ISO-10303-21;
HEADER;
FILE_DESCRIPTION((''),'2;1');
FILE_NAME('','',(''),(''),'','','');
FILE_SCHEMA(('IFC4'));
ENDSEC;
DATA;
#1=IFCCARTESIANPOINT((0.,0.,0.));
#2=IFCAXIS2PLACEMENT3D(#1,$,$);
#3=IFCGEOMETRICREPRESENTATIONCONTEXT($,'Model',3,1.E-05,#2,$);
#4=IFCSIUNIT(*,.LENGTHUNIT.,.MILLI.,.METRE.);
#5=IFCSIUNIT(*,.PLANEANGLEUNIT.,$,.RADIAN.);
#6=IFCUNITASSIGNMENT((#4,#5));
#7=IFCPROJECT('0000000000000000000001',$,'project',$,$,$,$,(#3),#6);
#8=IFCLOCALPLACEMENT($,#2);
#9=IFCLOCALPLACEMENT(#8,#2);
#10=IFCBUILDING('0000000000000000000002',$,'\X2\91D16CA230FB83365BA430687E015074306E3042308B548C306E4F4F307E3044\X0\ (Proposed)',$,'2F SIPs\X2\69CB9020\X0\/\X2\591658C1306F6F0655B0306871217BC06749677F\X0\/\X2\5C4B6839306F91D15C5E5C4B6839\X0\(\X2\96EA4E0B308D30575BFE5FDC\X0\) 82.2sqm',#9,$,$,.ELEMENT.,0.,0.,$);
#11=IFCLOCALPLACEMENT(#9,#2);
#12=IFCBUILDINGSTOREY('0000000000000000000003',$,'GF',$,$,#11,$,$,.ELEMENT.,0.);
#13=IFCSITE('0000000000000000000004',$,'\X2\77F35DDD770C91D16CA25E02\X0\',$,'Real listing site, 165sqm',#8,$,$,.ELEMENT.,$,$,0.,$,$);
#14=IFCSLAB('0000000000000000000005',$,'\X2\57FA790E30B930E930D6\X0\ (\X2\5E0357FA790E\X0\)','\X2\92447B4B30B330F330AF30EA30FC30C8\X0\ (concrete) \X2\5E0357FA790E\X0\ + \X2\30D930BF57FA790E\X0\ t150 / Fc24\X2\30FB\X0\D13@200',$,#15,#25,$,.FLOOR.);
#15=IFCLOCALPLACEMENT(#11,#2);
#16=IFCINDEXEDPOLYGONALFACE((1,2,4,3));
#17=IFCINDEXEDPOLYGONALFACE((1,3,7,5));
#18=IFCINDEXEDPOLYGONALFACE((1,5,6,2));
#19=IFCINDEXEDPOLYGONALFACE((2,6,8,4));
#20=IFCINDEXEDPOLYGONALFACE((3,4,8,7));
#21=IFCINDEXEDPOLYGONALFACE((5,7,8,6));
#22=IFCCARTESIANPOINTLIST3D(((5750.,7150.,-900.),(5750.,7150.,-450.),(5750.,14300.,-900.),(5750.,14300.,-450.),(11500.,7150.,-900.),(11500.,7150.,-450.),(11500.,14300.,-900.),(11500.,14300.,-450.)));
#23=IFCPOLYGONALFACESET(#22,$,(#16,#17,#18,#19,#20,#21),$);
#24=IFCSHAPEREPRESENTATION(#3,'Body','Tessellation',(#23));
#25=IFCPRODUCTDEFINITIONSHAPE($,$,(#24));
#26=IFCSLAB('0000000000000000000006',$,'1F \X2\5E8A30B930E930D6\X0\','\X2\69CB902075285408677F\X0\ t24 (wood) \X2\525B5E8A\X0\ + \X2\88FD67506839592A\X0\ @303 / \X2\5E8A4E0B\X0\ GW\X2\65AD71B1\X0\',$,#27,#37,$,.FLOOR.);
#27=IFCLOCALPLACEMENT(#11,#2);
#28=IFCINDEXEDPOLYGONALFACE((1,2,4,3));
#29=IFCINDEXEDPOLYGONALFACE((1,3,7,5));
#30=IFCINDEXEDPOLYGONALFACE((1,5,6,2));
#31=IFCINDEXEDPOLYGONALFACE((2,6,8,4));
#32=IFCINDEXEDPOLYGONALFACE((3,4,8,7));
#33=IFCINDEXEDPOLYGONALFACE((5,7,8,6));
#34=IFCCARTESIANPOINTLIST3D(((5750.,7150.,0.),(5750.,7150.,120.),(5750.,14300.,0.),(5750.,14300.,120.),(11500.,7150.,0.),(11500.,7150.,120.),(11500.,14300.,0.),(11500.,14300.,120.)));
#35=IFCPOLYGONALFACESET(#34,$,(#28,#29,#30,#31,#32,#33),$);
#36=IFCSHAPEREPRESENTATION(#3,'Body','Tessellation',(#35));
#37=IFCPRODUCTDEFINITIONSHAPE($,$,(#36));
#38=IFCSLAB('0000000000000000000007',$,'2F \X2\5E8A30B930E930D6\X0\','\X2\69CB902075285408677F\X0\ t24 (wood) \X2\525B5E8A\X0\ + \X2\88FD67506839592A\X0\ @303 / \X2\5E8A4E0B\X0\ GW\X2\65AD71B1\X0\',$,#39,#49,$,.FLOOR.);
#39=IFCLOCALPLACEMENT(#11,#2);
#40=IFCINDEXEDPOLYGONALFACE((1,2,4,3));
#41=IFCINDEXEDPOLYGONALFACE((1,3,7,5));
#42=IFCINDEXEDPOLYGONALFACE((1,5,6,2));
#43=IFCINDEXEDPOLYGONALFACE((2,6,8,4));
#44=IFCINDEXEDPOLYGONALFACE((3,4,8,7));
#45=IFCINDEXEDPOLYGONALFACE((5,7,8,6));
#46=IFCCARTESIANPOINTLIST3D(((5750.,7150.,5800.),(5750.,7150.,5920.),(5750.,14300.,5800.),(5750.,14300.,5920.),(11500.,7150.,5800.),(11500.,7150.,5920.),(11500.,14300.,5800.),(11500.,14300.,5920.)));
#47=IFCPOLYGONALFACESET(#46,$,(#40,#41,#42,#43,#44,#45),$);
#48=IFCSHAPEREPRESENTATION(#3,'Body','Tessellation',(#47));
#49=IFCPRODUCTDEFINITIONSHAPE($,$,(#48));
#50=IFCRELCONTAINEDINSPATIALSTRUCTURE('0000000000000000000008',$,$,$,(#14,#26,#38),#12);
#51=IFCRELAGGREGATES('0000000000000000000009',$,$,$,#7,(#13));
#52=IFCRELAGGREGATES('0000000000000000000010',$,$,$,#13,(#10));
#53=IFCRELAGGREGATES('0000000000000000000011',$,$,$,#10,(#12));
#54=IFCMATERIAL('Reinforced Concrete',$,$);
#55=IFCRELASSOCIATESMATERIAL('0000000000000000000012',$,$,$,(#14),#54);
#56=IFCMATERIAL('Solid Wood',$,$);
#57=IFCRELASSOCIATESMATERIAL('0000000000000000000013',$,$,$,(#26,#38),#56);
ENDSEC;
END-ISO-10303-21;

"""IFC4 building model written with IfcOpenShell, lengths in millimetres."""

from ifc_helpers import new_model, si_unit, frame, frame_2d, origin, place, context, project, spatial, rectangle, extrude, material, element, save


model = new_model("IFC4")

# Units and contexts
model_context = context("Model", 3, precision=1e-05, world=origin())
ifc_project = project(units=[si_unit("LENGTHUNIT", "METRE", prefix="MILLI"), si_unit("PLANEANGLEUNIT", "RADIAN")], contexts=[model_context])

# Site, building, storey
site_placement = place(None, origin())
site = spatial("IfcSite", under=ifc_project, at=site_placement, Name="石川県金沢市", ObjectType="Real listing site, 165sqm", CompositionType="ELEMENT", RefElevation=0.0)
building_placement = place(site_placement, origin())
building = spatial("IfcBuilding", under=site, at=building_placement, Name="金沢・茶室と縁側のある和の住まい (Proposed)", ObjectType="2F SIPs構造/外壁は漆喰と無節杉板/屋根は金属屋根(雪下ろし対応) 82.2sqm", CompositionType="ELEMENT", ElevationOfRefHeight=0.0, ElevationOfTerrain=0.0)
storey_placement = place(building_placement, origin())
storey = spatial("IfcBuildingStorey", under=building, at=storey_placement, Name="GF", CompositionType="ELEMENT", Elevation=0.0)

# Shared definitions
ifc_material_1 = material(Name="Solid Wood")

# Slabs
ifc_material_2 = material(Name="Reinforced Concrete")
slab_1_placement = place(storey_placement, frame((2875.0, 3575.0, -450.0)))
element("IfcSlab", 1, at=slab_1_placement, inside=storey, material=ifc_material_2, Name="基礎スラブ (布基礎)", Description="鉄筋コンクリート (concrete) 布基礎 + ベタ基礎 t150 / Fc24・D13@200", PredefinedType="FLOOR", context=model_context, shape_type="SweptSolid", body=[
    extrude(rectangle(XDim=5750.0, YDim=7150.0, at=frame_2d((2875.0, 3575.0))), frame((2875.0, 3575.0, -450.0)), (0.0, 0.0, 1.0), 450.0),
])
slab_2_placement = place(storey_placement, frame((2875.0, 3575.0, 0.0)))
element("IfcSlab", 2, at=slab_2_placement, inside=storey, material=ifc_material_1, Name="1F 床スラブ", Description="構造用合板 t24 (wood) 剛床 + 製材根太 @303 / 床下 GW断熱", PredefinedType="FLOOR", context=model_context, shape_type="SweptSolid", body=[
    extrude(rectangle(XDim=5750.0, YDim=7150.0, at=frame_2d((2875.0, 3575.0))), frame((2875.0, 3575.0, 0.0)), (0.0, 0.0, 1.0), 120.0),
])
slab_3_placement = place(storey_placement, frame((2875.0, 3575.0, 2900.0)))
element("IfcSlab", 3, at=slab_3_placement, inside=storey, material=ifc_material_1, Name="2F 床スラブ", Description="構造用合板 t24 (wood) 剛床 + 製材根太 @303 / 床下 GW断熱", PredefinedType="FLOOR", context=model_context, shape_type="SweptSolid", body=[
    extrude(rectangle(XDim=5750.0, YDim=7150.0, at=frame_2d((2875.0, 3575.0))), frame((2875.0, 3575.0, 2900.0)), (0.0, 0.0, 1.0), 120.0),
])

save(model, "model.ifc")
